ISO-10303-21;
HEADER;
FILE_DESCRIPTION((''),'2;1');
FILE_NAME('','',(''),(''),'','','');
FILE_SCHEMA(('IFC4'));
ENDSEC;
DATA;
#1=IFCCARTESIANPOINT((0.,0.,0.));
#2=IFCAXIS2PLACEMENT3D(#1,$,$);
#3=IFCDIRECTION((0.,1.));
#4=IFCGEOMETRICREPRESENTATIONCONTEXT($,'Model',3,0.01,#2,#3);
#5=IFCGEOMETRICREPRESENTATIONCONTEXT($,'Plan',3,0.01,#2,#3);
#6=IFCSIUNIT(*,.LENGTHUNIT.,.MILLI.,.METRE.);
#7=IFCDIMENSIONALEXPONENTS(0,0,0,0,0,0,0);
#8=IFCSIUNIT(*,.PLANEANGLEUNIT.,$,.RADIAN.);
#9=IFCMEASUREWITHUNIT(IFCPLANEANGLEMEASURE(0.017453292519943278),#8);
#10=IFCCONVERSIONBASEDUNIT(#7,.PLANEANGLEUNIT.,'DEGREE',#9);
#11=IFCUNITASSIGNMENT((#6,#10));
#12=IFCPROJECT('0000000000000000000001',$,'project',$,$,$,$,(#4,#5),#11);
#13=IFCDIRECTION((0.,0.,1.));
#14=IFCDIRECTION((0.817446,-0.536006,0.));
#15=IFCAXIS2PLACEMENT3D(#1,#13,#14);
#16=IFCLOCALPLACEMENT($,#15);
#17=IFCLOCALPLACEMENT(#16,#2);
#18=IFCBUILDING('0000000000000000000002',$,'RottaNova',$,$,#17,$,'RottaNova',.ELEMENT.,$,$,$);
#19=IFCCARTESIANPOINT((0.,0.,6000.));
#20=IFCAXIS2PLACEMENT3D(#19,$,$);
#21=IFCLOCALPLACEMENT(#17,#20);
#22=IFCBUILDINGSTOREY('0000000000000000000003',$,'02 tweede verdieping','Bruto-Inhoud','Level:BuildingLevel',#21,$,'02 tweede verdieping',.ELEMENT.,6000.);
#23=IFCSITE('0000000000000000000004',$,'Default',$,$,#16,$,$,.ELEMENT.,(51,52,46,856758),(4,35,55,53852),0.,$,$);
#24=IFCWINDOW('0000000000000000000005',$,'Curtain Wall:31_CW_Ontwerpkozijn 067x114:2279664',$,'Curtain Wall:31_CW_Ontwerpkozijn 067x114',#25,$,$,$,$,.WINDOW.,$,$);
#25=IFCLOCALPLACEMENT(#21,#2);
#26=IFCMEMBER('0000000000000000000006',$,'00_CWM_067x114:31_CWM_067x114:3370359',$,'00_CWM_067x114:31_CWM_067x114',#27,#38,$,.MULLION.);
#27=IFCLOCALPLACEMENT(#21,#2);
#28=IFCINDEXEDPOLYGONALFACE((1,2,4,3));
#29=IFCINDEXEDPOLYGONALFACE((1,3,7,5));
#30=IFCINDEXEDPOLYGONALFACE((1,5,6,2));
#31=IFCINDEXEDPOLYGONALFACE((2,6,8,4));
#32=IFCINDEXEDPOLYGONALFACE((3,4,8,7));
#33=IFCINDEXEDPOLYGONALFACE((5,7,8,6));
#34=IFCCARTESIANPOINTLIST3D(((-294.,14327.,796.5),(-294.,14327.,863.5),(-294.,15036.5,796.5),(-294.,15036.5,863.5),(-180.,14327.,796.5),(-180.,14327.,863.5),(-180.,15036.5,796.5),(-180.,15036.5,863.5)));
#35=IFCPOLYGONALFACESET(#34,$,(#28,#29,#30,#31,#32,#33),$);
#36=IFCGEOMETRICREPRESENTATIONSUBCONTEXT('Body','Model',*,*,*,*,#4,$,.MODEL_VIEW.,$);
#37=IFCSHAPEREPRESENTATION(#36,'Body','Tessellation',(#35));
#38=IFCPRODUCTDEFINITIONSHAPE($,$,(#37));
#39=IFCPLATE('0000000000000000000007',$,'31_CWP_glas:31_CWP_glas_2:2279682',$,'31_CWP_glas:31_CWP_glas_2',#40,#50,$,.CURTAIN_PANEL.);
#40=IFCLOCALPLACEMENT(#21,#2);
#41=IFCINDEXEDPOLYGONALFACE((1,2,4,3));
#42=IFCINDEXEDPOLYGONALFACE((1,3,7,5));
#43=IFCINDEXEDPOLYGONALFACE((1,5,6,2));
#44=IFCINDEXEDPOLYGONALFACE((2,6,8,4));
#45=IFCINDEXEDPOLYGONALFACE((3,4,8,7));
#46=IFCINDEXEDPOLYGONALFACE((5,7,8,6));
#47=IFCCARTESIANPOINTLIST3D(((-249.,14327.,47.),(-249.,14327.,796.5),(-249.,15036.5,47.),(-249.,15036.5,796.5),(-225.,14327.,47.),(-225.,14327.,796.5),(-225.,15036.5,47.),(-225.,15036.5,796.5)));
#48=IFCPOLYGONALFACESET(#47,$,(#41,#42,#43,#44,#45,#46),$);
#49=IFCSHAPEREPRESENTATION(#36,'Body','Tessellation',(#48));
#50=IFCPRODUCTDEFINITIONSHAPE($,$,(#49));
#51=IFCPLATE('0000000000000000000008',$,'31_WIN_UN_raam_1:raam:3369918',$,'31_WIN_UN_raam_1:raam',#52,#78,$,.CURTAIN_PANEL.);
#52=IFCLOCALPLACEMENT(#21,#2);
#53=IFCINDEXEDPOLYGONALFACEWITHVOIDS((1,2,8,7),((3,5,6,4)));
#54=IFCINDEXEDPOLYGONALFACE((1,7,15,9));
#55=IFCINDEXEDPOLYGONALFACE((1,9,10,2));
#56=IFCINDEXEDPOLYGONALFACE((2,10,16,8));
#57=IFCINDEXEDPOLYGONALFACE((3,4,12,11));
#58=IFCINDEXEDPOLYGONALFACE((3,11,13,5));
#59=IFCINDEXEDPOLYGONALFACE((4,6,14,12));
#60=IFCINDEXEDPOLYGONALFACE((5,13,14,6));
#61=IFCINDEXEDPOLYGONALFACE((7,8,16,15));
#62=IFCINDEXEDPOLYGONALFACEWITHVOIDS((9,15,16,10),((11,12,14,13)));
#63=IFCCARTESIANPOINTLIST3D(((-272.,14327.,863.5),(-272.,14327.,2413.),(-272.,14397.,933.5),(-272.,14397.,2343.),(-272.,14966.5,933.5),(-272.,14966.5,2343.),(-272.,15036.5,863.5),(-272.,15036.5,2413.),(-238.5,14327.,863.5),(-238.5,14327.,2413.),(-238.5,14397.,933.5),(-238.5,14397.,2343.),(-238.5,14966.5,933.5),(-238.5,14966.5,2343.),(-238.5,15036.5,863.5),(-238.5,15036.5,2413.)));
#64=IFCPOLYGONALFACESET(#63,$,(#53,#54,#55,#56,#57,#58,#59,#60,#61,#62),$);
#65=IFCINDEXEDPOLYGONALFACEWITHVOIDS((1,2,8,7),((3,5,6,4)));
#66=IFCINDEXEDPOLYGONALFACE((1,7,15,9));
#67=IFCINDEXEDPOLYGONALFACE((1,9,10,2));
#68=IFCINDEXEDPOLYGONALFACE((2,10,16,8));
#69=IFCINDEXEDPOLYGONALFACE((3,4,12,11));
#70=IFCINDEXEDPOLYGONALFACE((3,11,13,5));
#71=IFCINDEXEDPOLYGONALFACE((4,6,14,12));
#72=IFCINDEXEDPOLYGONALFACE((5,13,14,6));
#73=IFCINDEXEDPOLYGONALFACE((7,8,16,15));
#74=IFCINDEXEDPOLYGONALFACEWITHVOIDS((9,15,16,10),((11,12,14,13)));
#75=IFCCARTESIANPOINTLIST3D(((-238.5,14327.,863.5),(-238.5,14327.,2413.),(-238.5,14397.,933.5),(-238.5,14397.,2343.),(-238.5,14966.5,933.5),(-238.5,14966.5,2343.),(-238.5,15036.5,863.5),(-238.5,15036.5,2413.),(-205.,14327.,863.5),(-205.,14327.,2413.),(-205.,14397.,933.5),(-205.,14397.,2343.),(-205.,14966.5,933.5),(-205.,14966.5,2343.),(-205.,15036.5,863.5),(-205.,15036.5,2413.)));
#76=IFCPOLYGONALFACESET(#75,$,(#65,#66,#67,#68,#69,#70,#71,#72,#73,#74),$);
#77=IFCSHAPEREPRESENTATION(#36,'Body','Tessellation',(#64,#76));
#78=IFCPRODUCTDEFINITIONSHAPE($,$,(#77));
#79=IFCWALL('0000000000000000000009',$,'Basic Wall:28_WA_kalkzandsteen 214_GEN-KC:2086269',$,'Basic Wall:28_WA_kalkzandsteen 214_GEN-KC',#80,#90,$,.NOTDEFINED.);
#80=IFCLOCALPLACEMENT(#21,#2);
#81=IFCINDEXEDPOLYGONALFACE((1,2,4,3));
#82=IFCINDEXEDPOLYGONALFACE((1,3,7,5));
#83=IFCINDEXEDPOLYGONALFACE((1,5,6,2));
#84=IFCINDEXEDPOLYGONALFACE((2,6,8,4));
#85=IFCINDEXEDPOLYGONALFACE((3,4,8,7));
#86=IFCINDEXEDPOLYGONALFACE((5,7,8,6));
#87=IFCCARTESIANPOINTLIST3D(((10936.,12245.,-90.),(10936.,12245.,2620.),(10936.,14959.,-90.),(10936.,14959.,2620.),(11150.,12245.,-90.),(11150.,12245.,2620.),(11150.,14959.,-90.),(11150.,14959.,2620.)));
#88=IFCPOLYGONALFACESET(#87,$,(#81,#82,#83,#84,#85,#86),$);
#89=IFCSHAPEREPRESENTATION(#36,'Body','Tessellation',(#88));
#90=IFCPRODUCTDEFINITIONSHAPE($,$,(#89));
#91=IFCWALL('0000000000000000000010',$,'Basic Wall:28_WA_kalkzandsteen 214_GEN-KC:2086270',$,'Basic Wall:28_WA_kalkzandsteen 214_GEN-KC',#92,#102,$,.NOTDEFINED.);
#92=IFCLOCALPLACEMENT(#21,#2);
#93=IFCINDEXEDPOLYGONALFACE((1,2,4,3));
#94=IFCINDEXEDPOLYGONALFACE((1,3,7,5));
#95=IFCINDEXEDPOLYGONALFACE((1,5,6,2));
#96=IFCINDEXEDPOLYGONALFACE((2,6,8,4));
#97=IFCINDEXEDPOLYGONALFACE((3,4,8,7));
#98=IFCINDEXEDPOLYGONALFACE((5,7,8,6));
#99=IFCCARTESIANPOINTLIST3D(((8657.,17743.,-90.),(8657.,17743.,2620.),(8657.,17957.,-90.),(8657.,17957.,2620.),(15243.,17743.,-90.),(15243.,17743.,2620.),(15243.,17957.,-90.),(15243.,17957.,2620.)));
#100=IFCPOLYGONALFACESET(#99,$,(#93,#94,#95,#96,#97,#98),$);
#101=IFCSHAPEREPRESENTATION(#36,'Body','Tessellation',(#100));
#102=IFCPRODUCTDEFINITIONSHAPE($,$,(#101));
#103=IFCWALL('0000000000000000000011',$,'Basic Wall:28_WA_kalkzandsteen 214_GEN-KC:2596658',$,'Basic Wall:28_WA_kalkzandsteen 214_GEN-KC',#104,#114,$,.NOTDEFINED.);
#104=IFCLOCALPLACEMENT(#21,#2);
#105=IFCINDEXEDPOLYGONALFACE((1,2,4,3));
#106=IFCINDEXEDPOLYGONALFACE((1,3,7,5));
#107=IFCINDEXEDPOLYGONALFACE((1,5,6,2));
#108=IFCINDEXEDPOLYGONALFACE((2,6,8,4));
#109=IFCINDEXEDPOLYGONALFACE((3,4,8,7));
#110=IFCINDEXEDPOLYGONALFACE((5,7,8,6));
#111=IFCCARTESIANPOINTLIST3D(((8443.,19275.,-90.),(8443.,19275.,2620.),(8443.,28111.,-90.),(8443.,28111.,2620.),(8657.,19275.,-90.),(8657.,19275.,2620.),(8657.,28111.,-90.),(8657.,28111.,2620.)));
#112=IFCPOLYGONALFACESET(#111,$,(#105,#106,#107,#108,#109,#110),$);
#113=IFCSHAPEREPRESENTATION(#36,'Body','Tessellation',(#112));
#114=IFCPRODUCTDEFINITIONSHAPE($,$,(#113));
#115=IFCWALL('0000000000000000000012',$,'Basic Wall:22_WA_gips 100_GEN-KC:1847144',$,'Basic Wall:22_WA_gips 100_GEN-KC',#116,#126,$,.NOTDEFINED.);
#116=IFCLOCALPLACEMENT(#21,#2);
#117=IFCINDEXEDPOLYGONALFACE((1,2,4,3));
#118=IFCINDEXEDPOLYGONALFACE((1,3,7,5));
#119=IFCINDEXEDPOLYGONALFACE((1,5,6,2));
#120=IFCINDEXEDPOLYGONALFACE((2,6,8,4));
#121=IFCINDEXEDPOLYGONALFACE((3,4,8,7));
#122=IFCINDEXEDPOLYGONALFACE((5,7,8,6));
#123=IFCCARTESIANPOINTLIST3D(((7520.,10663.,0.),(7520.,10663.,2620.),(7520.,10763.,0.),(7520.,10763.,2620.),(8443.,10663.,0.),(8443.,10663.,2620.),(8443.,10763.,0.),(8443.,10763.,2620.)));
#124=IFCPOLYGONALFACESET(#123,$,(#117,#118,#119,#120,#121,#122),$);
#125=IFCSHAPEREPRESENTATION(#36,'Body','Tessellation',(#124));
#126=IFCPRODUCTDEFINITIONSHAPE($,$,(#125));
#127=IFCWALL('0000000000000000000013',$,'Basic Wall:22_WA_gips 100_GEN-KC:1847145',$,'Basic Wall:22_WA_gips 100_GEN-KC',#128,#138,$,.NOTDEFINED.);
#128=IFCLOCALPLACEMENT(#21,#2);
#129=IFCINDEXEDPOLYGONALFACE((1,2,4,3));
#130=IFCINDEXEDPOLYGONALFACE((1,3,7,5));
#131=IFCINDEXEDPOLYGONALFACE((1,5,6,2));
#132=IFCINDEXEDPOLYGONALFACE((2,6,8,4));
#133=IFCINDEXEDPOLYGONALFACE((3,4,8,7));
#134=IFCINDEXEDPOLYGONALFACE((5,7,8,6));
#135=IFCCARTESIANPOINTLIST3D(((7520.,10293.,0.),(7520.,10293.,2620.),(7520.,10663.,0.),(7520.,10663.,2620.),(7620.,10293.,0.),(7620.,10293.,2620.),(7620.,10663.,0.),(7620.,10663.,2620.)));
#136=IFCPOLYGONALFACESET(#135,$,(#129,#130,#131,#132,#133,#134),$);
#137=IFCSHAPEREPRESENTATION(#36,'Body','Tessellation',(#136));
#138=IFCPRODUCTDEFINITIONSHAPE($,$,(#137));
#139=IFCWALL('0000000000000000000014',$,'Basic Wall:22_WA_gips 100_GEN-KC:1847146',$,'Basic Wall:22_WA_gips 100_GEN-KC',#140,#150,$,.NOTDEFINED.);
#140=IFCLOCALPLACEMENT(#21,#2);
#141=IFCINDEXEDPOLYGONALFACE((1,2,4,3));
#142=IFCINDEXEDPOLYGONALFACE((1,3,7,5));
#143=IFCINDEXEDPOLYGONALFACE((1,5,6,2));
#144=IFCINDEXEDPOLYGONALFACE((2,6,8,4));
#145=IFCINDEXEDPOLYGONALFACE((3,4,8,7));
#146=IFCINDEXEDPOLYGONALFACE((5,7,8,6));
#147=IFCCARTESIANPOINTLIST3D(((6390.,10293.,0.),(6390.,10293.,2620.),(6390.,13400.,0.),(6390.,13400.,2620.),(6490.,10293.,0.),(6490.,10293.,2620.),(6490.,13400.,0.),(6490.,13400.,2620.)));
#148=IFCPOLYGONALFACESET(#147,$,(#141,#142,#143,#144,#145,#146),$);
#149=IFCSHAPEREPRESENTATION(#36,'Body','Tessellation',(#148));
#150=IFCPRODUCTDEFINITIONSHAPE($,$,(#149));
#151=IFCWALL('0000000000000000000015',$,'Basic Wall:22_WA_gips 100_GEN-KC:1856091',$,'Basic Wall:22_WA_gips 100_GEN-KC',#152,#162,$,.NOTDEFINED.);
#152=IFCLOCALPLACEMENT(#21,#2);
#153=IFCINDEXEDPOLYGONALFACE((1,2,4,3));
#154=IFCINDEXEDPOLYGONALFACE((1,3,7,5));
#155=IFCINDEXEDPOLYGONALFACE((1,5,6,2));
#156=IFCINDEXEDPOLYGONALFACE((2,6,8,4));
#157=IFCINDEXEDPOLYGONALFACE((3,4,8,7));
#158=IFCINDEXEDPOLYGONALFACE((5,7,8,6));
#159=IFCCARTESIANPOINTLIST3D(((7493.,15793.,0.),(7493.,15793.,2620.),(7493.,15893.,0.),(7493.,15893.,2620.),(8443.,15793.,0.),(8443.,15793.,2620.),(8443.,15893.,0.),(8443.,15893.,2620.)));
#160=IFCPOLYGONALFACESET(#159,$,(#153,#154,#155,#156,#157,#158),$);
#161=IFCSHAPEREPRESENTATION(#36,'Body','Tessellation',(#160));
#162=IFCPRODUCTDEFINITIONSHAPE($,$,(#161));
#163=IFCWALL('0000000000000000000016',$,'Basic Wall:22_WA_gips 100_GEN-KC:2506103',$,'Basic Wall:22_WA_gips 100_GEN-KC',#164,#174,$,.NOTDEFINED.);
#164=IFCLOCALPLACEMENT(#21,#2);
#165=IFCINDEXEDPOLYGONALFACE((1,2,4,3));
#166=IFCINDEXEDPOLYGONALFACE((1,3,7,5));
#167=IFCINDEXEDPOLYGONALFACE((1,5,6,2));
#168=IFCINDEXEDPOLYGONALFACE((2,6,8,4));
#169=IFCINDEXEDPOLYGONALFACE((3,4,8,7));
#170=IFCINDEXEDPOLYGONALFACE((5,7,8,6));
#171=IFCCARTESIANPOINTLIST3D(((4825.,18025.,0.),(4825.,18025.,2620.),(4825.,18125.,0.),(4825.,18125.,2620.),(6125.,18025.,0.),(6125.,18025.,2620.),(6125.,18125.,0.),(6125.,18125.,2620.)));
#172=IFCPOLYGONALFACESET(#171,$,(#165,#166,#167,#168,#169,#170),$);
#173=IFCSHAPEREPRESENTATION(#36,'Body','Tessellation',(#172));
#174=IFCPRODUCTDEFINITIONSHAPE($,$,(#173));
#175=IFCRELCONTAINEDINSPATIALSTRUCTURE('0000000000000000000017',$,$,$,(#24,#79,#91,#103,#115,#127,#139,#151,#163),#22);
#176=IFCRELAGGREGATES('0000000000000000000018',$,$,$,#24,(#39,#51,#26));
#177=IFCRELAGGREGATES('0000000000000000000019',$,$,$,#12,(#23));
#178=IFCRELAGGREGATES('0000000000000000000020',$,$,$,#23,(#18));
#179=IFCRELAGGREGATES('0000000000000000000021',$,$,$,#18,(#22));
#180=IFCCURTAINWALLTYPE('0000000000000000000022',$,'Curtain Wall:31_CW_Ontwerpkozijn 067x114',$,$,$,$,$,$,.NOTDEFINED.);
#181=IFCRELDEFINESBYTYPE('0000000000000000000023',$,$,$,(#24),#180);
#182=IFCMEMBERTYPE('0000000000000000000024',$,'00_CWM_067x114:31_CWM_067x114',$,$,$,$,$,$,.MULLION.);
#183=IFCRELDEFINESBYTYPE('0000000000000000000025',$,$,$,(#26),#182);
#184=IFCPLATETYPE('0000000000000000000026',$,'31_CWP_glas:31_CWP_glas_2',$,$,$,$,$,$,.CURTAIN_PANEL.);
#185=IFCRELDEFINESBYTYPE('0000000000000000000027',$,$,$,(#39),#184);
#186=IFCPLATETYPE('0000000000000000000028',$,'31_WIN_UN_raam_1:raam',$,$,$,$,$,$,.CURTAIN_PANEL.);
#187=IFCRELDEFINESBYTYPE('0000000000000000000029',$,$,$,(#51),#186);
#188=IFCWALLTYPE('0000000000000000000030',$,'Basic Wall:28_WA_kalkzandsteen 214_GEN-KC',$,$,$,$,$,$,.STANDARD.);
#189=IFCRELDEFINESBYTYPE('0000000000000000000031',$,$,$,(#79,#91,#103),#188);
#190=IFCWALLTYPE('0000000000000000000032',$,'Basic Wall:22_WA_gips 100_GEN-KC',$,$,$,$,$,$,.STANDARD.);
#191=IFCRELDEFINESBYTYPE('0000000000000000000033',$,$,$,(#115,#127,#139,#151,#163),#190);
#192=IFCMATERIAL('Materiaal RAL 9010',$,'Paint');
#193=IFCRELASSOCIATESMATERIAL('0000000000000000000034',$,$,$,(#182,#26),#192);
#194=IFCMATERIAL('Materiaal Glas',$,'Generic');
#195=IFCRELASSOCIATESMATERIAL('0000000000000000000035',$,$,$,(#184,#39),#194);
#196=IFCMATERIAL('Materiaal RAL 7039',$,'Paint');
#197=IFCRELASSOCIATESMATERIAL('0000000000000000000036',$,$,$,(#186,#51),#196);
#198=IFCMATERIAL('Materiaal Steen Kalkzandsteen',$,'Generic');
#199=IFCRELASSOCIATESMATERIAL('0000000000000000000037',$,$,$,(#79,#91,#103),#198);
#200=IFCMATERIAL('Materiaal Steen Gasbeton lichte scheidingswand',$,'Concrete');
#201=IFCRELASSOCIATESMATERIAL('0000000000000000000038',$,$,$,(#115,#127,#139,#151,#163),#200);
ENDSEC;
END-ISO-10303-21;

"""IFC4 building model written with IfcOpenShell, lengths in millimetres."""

from ifc_helpers import new_model, entity, si_unit, converted_unit, direction, frame, origin, place, context, subcontext, project, spatial, indexed_curve, outline, extrude, source, transform, mapped, material, type_object, type_shapes, element, aggregate, save


model = new_model("IFC4")

# Units and contexts
model_context = context("Model", 3, precision=0.01, world=origin(), true_north=direction((0.0, 1.0)))
plan_context = context("Plan", 3, precision=0.01, world=origin(), true_north=direction((0.0, 1.0)))
body_context = subcontext(model_context, "Body", "Model", "MODEL_VIEW")
ifc_project = project(units=[si_unit("LENGTHUNIT", "METRE", prefix="MILLI"), converted_unit("PLANEANGLEUNIT", "DEGREE", entity("IfcPlaneAngleMeasure", 0.017453292519943278), si_unit("PLANEANGLEUNIT", "RADIAN"), dimensions=[0, 0, 0, 0, 0, 0, 0])], contexts=[model_context, plan_context])

# Site, building, storey
site_placement = place(None, frame((0.0, 0.0, 0.0), z_axis=(0.0, 0.0, 1.0), x_axis=(0.817446, -0.536006, 0.0)))
site = spatial("IfcSite", under=ifc_project, at=site_placement, Name="Default", CompositionType="ELEMENT", RefLatitude=(51, 52, 46, 856758), RefLongitude=(4, 35, 55, 53852), RefElevation=0.0)
building_placement = place(site_placement, origin())
building = spatial("IfcBuilding", under=site, at=building_placement, Name="RottaNova", LongName="RottaNova", CompositionType="ELEMENT")
storey_placement = place(building_placement, frame((0.0, 0.0, 6000.0)))
storey = spatial("IfcBuildingStorey", under=building, at=storey_placement, Name="02 tweede verdieping", Description="Bruto-Inhoud", ObjectType="Level:BuildingLevel", LongName="02 tweede verdieping", CompositionType="ELEMENT", Elevation=6000.0)

# Window, member, plates
curtain_wall_type = type_object("IfcCurtainWallType", Name="Curtain Wall:31_CW_Ontwerpkozijn 067x114", PredefinedType="NOTDEFINED")
window_1_placement = place(storey_placement, frame((0.0, 0.0, -6000.0)))
window_1 = element("IfcWindow", 1, at=window_1_placement, inside=storey, type_object=curtain_wall_type, Name="Curtain Wall:31_CW_Ontwerpkozijn 067x114:2279664", ObjectType="Curtain Wall:31_CW_Ontwerpkozijn 067x114", PredefinedType="WINDOW")
ifc_material_1 = material(Name="Materiaal RAL 9010", Category="Paint")
member_type = type_object("IfcMemberType", Name="00_CWM_067x114:31_CWM_067x114", PredefinedType="MULLION", material=ifc_material_1)
shared_shape_1 = source(origin(), body_context, "Body", "SweptSolid", [
    extrude(outline(indexed_curve([(-33.5, -57.0), (33.5, -57.0), (33.5, 57.0), (-33.5, 57.0), (-33.5, -57.0)], self_intersect=False)), frame((0.0, 57.0, -709.5), z_axis=(0.0, 0.0, 1.0), x_axis=(-1.0, 0.0, 0.0)), (0.0, 0.0, 1.0), 709.5),
])
type_shapes(member_type, [shared_shape_1])
member_placement = place(window_1_placement, frame((-180.0, 14327.0, 6830.0), z_axis=(0.0, -1.0, 0.0), x_axis=(0.0, 0.0, 1.0)))
member = element("IfcMember", 2, at=member_placement, type_object=member_type, material=ifc_material_1, Name="00_CWM_067x114:31_CWM_067x114:3370359", ObjectType="00_CWM_067x114:31_CWM_067x114", PredefinedType="MULLION", context=body_context, shape_type="MappedRepresentation", body=[
    mapped(shared_shape_1, transform((0.0, 0.0, 0.0), scale=1.0)),
])
ifc_material_2 = material(Name="Materiaal Glas", Category="Generic")
plate_type_1 = type_object("IfcPlateType", Name="31_CWP_glas:31_CWP_glas_2", PredefinedType="CURTAIN_PANEL", material=ifc_material_2)
shared_shape_2 = source(origin(), body_context, "Body", "SweptSolid", [
    extrude(outline(indexed_curve([(-12.0, -354.8), (12.0, -354.8), (12.0, 354.8), (-12.0, 354.8), (-12.0, -354.8)], self_intersect=False)), frame((0.0, -57.0, 0.0), z_axis=(0.0, 0.0, 1.0), x_axis=(0.0, 1.0, 0.0)), (0.0, 0.0, 1.0), 749.5),
])
type_shapes(plate_type_1, [shared_shape_2])
plate_1_placement = place(window_1_placement, frame((-180.0, 14681.8, 6047.0), z_axis=(0.0, 0.0, 1.0), x_axis=(0.0, -1.0, 0.0)))
plate_1 = element("IfcPlate", 3, at=plate_1_placement, type_object=plate_type_1, material=ifc_material_2, Name="31_CWP_glas:31_CWP_glas_2:2279682", ObjectType="31_CWP_glas:31_CWP_glas_2", PredefinedType="CURTAIN_PANEL", context=body_context, shape_type="MappedRepresentation", body=[
    mapped(shared_shape_2, transform((0.0, 0.0, 0.0), scale=1.0)),
])
ifc_material_3 = material(Name="Materiaal RAL 7039", Category="Paint")
plate_type_2 = type_object("IfcPlateType", Name="31_WIN_UN_raam_1:raam", PredefinedType="CURTAIN_PANEL", material=ifc_material_3)
shared_shape_3 = source(origin(), body_context, "Body", "SweptSolid", [
    extrude(outline(indexed_curve([(-354.7, -774.7), (354.7, -774.7), (354.7, 774.7), (-354.7, 774.7), (-354.7, -774.7)], self_intersect=False), holes=[indexed_curve([(-284.7, 704.7), (284.7, 704.7), (284.7, -704.8), (-284.7, -704.8), (-284.7, 704.7)], self_intersect=False)]), frame((0.0, -92.0, 774.8), z_axis=(0.0, 1.0, 0.0), x_axis=(1.0, 0.0, 0.0)), (0.0, 0.0, 1.0), 33.5),
    extrude(outline(indexed_curve([(-354.7, -774.7), (354.7, -774.7), (354.7, 774.7), (-354.7, 774.7), (-354.7, -774.7)], self_intersect=False), holes=[indexed_curve([(-284.7, 704.7), (284.7, 704.7), (284.7, -704.8), (-284.7, -704.8), (-284.7, 704.7)], self_intersect=False)]), frame((0.0, -58.5, 774.8), z_axis=(0.0, 1.0, 0.0), x_axis=(1.0, 0.0, 0.0)), (0.0, 0.0, 1.0), 33.5),
])
type_shapes(plate_type_2, [shared_shape_3])
plate_2_placement = place(window_1_placement, frame((-180.0, 14681.8, 6863.5), z_axis=(0.0, 0.0, 1.0), x_axis=(0.0, -1.0, 0.0)))
plate_2 = element("IfcPlate", 4, at=plate_2_placement, type_object=plate_type_2, material=ifc_material_3, Name="31_WIN_UN_raam_1:raam:3369918", ObjectType="31_WIN_UN_raam_1:raam", PredefinedType="CURTAIN_PANEL", context=body_context, shape_type="MappedRepresentation", body=[
    mapped(shared_shape_3, transform((0.0, 0.0, 0.0), scale=1.0)),
])
aggregate(window_1, [plate_1, plate_2, member])

# Walls
ifc_material_4 = material(Name="Materiaal Steen Kalkzandsteen", Category="Generic")
wall_type_1 = type_object("IfcWallType", Name="Basic Wall:28_WA_kalkzandsteen 214_GEN-KC", PredefinedType="STANDARD")
wall_1_placement = place(storey_placement, frame((11043.0, 12245.0, -90.0), z_axis=(0.0, 0.0, 1.0), x_axis=(0.0, 1.0, 0.0)))
element("IfcWall", 5, at=wall_1_placement, inside=storey, type_object=wall_type_1, material=ifc_material_4, Name="Basic Wall:28_WA_kalkzandsteen 214_GEN-KC:2086269", ObjectType="Basic Wall:28_WA_kalkzandsteen 214_GEN-KC", PredefinedType="NOTDEFINED", context=body_context, shape_type="SweptSolid", body=[
    extrude(outline(indexed_curve([(2714.0, 107.0), (0.0, 107.0), (0.0, -107.0), (2714.0, -107.0), (2714.0, 107.0)], self_intersect=False)), origin(), (0.0, 0.0, 1.0), 2710.0),
])
wall_2_placement = place(storey_placement, frame((8657.0, 17850.0, -90.0)))
element("IfcWall", 6, at=wall_2_placement, inside=storey, type_object=wall_type_1, material=ifc_material_4, Name="Basic Wall:28_WA_kalkzandsteen 214_GEN-KC:2086270", ObjectType="Basic Wall:28_WA_kalkzandsteen 214_GEN-KC", PredefinedType="NOTDEFINED", context=body_context, shape_type="SweptSolid", body=[
    extrude(outline(indexed_curve([(6586.0, 107.0), (0.0, 107.0), (0.0, -107.0), (6586.0, -107.0), (6586.0, 107.0)], self_intersect=False)), origin(), (0.0, 0.0, 1.0), 2710.0),
])
wall_3_placement = place(storey_placement, frame((8550.0, 19275.0, -90.0), z_axis=(0.0, 0.0, 1.0), x_axis=(0.0, 1.0, 0.0)))
element("IfcWall", 7, at=wall_3_placement, inside=storey, type_object=wall_type_1, material=ifc_material_4, Name="Basic Wall:28_WA_kalkzandsteen 214_GEN-KC:2596658", ObjectType="Basic Wall:28_WA_kalkzandsteen 214_GEN-KC", PredefinedType="NOTDEFINED", context=body_context, shape_type="SweptSolid", body=[
    extrude(outline(indexed_curve([(-4418.0, -107.0), (4418.0, -107.0), (4418.0, 107.0), (-4418.0, 107.0), (-4418.0, -107.0)], self_intersect=False)), frame((4418.0, 0.0, 0.0), z_axis=(0.0, 0.0, 1.0), x_axis=(-1.0, 0.0, 0.0)), (0.0, 0.0, 1.0), 2710.0),
])
ifc_material_5 = material(Name="Materiaal Steen Gasbeton lichte scheidingswand", Category="Concrete")
wall_type_2 = type_object("IfcWallType", Name="Basic Wall:22_WA_gips 100_GEN-KC", PredefinedType="STANDARD")
wall_4_placement = place(storey_placement, frame((7520.0, 10713.0, 0.0)))
element("IfcWall", 8, at=wall_4_placement, inside=storey, type_object=wall_type_2, material=ifc_material_5, Name="Basic Wall:22_WA_gips 100_GEN-KC:1847144", ObjectType="Basic Wall:22_WA_gips 100_GEN-KC", PredefinedType="NOTDEFINED", context=body_context, shape_type="SweptSolid", body=[
    extrude(outline(indexed_curve([(923.0, 50.0), (0.0, 50.0), (0.0, -50.0), (923.0, -50.0), (923.0, 50.0)], self_intersect=False)), origin(), (0.0, 0.0, 1.0), 2620.0),
])
wall_5_placement = place(storey_placement, frame((7570.0, 10663.0, 0.0), z_axis=(0.0, 0.0, 1.0), x_axis=(0.0, -1.0, 0.0)))
element("IfcWall", 9, at=wall_5_placement, inside=storey, type_object=wall_type_2, material=ifc_material_5, Name="Basic Wall:22_WA_gips 100_GEN-KC:1847145", ObjectType="Basic Wall:22_WA_gips 100_GEN-KC", PredefinedType="NOTDEFINED", context=body_context, shape_type="SweptSolid", body=[
    extrude(outline(indexed_curve([(370.0, 50.0), (0.0, 50.0), (0.0, -50.0), (370.0, -50.0), (370.0, 50.0)], self_intersect=False)), origin(), (0.0, 0.0, 1.0), 2620.0),
])
wall_6_placement = place(storey_placement, frame((6440.0, 13400.0, 0.0), z_axis=(0.0, 0.0, 1.0), x_axis=(0.0, -1.0, 0.0)))
element("IfcWall", 10, at=wall_6_placement, inside=storey, type_object=wall_type_2, material=ifc_material_5, Name="Basic Wall:22_WA_gips 100_GEN-KC:1847146", ObjectType="Basic Wall:22_WA_gips 100_GEN-KC", PredefinedType="NOTDEFINED", context=body_context, shape_type="SweptSolid", body=[
    extrude(outline(indexed_curve([(3107.0, 50.0), (0.0, 50.0), (0.0, -50.0), (3107.0, -50.0), (3107.0, 50.0)], self_intersect=False)), origin(), (0.0, 0.0, 1.0), 2620.0),
])
wall_7_placement = place(storey_placement, frame((7493.0, 15843.0, 0.0)))
element("IfcWall", 11, at=wall_7_placement, inside=storey, type_object=wall_type_2, material=ifc_material_5, Name="Basic Wall:22_WA_gips 100_GEN-KC:1856091", ObjectType="Basic Wall:22_WA_gips 100_GEN-KC", PredefinedType="NOTDEFINED", context=body_context, shape_type="SweptSolid", body=[
    extrude(outline(indexed_curve([(950.0, 50.0), (0.0, 50.0), (0.0, -50.0), (950.0, -50.0), (950.0, 50.0)], self_intersect=False)), origin(), (0.0, 0.0, 1.0), 2620.0),
])
wall_8_placement = place(storey_placement, frame((4825.0, 18075.0, 0.0)))
element("IfcWall", 12, at=wall_8_placement, inside=storey, type_object=wall_type_2, material=ifc_material_5, Name="Basic Wall:22_WA_gips 100_GEN-KC:2506103", ObjectType="Basic Wall:22_WA_gips 100_GEN-KC", PredefinedType="NOTDEFINED", context=body_context, shape_type="SweptSolid", body=[
    extrude(outline(indexed_curve([(1300.0, 50.0), (0.0, 50.0), (0.0, -50.0), (1300.0, -50.0), (1300.0, 50.0)], self_intersect=False)), origin(), (0.0, 0.0, 1.0), 2620.0),
])

save(model, "model.ifc")
